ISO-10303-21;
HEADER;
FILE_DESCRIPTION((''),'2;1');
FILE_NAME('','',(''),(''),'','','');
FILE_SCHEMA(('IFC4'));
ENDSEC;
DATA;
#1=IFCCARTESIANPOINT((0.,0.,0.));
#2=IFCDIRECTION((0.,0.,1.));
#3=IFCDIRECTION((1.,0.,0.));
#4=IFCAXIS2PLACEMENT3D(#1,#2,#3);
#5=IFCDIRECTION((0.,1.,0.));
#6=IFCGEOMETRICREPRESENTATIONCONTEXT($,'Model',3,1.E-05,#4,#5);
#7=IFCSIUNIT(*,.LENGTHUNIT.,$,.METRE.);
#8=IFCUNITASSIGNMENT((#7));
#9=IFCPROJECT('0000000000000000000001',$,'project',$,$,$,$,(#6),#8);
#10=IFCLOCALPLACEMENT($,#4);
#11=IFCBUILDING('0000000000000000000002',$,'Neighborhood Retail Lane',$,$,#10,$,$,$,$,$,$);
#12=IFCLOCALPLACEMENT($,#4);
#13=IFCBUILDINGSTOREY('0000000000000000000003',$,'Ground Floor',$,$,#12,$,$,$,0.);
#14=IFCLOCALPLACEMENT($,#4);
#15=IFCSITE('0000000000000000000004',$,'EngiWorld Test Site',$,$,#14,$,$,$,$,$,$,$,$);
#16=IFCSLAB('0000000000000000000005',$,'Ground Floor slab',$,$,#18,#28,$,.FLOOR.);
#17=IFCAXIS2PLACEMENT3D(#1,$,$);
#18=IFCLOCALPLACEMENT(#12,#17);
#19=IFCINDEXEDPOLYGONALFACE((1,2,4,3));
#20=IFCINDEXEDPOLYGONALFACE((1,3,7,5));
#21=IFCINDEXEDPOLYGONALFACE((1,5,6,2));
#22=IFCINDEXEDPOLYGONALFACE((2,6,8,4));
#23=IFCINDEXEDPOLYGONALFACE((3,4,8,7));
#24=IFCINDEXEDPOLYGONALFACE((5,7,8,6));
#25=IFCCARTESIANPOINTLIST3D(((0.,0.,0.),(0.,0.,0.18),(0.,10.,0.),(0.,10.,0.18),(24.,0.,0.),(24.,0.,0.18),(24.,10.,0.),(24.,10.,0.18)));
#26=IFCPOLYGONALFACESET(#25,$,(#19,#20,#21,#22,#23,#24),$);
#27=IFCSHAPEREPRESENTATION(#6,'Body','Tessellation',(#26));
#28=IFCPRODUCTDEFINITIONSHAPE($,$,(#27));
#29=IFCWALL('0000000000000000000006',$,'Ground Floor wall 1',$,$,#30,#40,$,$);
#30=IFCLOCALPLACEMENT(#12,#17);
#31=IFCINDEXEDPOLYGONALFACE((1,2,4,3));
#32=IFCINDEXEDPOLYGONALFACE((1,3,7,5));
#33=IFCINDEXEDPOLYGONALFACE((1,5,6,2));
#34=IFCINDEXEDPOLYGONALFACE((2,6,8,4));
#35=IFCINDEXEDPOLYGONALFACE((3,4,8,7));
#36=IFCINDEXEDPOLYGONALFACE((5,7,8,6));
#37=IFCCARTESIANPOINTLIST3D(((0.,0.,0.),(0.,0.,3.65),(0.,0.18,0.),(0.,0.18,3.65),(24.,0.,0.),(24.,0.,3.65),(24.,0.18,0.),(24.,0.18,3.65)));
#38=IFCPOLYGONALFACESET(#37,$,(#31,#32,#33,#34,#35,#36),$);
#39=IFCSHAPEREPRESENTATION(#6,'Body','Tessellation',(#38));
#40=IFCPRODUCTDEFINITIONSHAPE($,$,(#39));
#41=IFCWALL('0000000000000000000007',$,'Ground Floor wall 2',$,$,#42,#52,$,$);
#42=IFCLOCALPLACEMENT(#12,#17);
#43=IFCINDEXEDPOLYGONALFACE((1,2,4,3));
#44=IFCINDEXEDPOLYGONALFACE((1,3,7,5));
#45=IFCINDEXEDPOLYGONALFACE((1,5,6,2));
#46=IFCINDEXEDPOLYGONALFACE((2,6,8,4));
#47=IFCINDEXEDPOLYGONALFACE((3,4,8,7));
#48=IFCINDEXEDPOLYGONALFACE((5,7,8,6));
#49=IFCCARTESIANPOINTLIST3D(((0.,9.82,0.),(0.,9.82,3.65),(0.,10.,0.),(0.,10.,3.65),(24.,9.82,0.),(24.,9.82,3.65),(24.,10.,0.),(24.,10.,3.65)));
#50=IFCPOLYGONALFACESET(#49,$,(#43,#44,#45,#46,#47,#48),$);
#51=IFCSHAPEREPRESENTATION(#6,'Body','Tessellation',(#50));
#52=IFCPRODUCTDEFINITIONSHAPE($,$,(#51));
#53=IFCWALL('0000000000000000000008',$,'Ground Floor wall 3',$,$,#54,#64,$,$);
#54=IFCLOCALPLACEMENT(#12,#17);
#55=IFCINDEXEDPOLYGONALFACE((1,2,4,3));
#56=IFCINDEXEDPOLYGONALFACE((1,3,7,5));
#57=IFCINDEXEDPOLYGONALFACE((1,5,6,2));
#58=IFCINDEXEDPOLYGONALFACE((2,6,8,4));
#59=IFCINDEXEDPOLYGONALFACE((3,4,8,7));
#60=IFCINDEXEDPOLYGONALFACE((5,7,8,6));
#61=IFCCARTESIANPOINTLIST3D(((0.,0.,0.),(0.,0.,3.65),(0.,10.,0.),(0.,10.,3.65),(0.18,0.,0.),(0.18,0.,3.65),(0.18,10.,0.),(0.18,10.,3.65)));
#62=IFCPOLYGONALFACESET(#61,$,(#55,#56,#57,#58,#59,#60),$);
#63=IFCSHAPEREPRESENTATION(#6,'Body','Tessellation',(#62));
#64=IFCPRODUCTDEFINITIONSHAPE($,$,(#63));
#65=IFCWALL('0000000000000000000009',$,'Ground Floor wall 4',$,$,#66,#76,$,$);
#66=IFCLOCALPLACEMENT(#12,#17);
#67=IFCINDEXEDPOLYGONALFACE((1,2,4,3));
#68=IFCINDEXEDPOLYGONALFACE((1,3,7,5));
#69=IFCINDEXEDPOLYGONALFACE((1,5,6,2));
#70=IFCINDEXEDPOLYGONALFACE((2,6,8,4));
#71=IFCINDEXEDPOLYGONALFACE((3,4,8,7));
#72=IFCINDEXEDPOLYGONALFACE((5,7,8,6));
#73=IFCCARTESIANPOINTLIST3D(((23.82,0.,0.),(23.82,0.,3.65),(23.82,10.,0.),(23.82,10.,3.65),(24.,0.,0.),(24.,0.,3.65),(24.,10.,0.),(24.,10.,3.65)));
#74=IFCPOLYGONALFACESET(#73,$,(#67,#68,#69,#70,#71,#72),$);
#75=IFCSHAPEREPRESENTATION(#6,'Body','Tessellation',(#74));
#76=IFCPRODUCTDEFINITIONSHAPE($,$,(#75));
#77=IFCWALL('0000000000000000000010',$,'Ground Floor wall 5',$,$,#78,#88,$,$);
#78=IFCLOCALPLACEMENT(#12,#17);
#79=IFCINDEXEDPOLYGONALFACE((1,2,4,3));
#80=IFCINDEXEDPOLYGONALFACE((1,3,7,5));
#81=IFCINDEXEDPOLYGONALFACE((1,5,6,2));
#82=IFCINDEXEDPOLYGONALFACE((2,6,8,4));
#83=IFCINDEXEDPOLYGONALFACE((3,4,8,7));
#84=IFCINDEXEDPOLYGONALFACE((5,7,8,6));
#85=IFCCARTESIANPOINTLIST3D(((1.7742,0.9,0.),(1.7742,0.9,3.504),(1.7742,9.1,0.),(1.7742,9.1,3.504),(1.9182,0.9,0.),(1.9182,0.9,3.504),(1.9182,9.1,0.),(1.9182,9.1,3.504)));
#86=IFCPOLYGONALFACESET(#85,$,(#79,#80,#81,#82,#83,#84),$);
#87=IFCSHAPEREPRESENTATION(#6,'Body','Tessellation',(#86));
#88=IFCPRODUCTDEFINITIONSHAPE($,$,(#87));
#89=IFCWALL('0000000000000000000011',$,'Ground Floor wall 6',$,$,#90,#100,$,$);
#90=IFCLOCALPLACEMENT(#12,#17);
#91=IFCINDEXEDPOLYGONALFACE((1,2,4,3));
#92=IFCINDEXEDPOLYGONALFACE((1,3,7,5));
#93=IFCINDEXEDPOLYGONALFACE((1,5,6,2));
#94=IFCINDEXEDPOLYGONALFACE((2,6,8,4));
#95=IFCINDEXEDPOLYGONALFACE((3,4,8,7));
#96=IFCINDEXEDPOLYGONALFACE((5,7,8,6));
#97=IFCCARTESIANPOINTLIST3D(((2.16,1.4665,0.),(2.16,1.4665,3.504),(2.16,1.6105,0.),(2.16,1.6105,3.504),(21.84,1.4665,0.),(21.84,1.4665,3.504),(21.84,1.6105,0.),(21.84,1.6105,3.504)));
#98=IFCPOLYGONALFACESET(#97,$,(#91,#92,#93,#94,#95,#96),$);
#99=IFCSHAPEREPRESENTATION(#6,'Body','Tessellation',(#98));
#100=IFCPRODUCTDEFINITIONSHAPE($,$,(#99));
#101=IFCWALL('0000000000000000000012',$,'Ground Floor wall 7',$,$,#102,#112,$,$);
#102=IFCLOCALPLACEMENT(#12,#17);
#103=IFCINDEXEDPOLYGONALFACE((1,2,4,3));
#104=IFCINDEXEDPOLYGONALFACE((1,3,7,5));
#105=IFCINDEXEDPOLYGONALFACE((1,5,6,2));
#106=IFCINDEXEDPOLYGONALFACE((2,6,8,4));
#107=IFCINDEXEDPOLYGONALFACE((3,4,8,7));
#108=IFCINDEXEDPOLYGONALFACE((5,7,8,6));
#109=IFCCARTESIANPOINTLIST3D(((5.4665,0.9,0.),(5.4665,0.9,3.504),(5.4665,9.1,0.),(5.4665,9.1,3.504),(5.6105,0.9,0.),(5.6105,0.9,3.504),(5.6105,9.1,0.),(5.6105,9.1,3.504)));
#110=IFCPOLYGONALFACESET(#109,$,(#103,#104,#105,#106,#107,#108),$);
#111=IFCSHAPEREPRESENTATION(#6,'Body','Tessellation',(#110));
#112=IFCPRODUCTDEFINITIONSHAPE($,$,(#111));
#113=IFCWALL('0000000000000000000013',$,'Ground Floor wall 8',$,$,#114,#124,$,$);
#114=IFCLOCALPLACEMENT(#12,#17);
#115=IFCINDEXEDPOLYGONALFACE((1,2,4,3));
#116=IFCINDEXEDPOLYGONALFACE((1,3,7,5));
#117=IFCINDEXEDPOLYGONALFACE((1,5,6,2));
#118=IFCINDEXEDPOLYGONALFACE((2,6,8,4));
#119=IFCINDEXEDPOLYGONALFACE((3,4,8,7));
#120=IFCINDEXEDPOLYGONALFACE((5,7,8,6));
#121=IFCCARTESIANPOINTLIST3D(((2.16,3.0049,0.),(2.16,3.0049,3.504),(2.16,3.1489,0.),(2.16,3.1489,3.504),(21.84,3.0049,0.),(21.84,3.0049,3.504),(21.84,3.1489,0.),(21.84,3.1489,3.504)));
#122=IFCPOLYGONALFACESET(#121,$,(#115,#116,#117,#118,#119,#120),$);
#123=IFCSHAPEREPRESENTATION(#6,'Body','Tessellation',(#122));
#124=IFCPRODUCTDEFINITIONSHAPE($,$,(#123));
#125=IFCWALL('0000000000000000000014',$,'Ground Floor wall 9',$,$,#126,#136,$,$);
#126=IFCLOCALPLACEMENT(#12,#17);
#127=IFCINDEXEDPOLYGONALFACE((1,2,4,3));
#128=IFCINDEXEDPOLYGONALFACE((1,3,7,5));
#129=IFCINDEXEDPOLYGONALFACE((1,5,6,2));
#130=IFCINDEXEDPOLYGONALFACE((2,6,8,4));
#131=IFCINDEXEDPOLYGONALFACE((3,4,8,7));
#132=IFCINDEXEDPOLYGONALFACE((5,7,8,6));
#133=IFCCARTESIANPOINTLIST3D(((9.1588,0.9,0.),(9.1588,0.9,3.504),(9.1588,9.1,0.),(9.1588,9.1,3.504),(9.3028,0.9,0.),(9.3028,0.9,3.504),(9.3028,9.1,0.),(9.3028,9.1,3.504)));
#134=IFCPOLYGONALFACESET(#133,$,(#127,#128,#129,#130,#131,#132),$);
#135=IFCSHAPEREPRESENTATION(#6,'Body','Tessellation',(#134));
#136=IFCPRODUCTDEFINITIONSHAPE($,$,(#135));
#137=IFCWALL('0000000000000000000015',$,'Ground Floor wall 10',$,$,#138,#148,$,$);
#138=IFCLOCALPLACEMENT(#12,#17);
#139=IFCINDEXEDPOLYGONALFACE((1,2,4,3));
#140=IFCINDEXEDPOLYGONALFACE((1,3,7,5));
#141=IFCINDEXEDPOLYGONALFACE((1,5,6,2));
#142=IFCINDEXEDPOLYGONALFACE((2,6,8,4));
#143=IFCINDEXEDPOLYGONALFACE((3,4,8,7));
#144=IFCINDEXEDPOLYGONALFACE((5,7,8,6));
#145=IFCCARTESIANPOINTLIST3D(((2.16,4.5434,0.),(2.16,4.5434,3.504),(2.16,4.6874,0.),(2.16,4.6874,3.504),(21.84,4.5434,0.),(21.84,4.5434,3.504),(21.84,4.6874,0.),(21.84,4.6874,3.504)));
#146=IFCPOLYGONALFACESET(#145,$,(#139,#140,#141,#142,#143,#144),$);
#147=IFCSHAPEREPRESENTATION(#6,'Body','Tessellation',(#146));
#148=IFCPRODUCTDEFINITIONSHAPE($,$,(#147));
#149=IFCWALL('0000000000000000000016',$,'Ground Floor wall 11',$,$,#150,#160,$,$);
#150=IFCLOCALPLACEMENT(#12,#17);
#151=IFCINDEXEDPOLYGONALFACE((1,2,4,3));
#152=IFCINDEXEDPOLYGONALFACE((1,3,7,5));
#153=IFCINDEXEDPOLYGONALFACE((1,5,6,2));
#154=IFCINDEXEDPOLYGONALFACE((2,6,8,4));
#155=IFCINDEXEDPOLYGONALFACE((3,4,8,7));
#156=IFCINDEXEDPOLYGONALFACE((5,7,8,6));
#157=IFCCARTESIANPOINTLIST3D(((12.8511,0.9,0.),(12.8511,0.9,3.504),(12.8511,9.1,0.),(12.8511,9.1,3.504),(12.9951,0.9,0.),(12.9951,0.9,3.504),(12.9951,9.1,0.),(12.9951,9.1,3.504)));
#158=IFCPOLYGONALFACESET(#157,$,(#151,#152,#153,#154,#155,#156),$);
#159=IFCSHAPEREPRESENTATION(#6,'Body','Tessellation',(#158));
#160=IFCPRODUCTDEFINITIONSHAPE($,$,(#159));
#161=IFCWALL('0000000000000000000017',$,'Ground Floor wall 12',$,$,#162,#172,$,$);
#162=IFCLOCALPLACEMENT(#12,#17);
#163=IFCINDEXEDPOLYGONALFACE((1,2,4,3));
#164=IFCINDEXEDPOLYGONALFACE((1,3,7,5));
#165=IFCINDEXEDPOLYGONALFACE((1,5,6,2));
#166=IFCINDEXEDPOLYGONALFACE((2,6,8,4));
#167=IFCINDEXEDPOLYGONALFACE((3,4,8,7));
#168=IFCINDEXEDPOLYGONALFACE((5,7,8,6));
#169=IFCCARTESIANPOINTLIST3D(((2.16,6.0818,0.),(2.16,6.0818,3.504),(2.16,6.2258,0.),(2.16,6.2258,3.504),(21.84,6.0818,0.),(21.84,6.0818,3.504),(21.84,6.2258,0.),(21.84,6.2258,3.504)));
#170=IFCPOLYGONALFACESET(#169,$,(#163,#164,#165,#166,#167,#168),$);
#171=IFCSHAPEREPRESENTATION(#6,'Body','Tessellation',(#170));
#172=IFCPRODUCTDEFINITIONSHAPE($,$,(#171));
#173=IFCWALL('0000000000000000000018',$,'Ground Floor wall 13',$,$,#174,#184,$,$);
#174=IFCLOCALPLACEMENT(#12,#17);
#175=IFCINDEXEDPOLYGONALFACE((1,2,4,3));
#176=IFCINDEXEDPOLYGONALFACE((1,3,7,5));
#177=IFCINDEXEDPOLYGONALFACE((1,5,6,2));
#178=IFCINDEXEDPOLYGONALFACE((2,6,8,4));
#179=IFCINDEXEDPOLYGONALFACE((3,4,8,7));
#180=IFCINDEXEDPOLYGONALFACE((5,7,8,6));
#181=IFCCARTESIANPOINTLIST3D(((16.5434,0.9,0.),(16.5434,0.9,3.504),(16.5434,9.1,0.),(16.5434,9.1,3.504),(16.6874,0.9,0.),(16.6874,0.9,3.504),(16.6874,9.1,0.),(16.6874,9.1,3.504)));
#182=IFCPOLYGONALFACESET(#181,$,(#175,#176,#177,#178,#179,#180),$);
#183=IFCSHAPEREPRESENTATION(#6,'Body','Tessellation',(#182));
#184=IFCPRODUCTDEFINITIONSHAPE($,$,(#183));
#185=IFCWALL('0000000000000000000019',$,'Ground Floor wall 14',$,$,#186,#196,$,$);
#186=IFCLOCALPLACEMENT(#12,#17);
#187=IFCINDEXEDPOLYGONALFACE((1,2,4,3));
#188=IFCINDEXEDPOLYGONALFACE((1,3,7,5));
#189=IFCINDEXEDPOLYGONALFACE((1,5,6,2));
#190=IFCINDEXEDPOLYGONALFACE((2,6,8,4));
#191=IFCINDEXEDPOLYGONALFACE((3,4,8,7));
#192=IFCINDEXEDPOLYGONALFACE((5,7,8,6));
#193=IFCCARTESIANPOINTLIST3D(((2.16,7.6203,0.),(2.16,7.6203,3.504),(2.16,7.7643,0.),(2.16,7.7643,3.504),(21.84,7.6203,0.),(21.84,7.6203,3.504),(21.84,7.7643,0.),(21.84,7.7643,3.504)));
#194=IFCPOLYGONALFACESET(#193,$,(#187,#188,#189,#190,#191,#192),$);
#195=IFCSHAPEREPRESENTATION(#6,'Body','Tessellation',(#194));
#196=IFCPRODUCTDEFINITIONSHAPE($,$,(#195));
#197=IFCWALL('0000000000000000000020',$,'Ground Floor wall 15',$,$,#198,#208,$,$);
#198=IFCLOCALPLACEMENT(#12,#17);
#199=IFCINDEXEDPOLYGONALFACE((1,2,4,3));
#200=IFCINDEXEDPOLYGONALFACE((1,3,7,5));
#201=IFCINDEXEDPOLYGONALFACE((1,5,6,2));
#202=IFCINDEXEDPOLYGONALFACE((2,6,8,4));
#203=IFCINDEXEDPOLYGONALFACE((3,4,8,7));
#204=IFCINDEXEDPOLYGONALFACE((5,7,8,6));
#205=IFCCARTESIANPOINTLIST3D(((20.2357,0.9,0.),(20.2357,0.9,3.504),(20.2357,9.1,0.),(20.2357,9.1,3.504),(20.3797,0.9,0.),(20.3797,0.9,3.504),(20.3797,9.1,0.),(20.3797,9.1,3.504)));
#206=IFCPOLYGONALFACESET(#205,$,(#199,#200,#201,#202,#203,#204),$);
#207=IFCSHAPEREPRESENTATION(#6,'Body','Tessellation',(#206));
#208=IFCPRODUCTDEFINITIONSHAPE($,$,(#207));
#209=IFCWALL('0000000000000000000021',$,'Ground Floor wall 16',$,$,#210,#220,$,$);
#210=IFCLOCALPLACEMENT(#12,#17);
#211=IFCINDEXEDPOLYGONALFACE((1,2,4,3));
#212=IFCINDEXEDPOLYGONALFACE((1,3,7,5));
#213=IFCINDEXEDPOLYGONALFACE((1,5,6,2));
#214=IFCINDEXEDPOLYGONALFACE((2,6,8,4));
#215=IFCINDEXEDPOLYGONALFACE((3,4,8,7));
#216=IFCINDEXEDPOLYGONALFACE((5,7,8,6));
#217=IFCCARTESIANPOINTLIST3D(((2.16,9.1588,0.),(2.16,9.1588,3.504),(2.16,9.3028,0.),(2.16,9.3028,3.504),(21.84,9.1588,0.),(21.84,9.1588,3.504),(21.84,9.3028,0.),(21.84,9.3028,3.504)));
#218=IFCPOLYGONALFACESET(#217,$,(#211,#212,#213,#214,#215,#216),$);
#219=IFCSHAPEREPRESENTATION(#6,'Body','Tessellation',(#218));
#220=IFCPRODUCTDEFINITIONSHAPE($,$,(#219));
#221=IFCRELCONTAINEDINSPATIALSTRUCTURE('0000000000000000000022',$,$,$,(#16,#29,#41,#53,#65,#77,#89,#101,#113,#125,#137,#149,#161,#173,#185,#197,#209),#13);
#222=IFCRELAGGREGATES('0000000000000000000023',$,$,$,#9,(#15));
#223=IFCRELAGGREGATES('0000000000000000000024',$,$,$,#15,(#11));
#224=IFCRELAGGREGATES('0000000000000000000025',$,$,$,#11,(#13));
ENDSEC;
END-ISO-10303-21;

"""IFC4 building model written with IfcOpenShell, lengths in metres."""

from ifc_helpers import new_model, si_unit, direction, frame, origin_with_axes, origin_2d_with_axis, place, context, project, spatial, rectangle, extrude, element, save


model = new_model("IFC4")

# Units and contexts
model_context = context("Model", 3, precision=1e-05, world=origin_with_axes(), true_north=direction((0.0, 1.0, 0.0)))
ifc_project = project(units=[si_unit("LENGTHUNIT", "METRE")], contexts=[model_context])

# Site, building, storey
site_placement = place(None, origin_with_axes())
site = spatial("IfcSite", under=ifc_project, at=site_placement, Name="EngiWorld Test Site")
building_placement = place(None, origin_with_axes())
building = spatial("IfcBuilding", under=site, at=building_placement, Name="Neighborhood Retail Lane")
storey_placement = place(None, origin_with_axes())
storey = spatial("IfcBuildingStorey", under=building, at=storey_placement, Name="Ground Floor", Elevation=0.0)

# Slab
slab_placement = place(None, frame((12.0, 5.0, 0.0), z_axis=(0.0, 0.0, 1.0), x_axis=(1.0, 0.0, 0.0)))
element("IfcSlab", 1, at=slab_placement, inside=storey, Name="Ground Floor slab", PredefinedType="FLOOR", context=model_context, shape_type="SweptSolid", body=[
    extrude(rectangle(XDim=24.0, YDim=10.0, at=origin_2d_with_axis()), origin_with_axes(), (0.0, 0.0, 1.0), 0.18),
])

# Walls
for number, where, z_axis, x_axis, name in (
    (2, (12.0, 0.09, 0.0), (0.0, 0.0, 1.0), (1.0, 0.0, 0.0), "Ground Floor wall 1"),
    (3, (12.0, 9.91, 0.0), (0.0, 0.0, 1.0), (1.0, 0.0, 0.0), "Ground Floor wall 2"),
):
    element("IfcWall", number, at=place(None, frame(where, z_axis=z_axis, x_axis=x_axis)), inside=storey, Name=name, context=model_context, shape_type="SweptSolid", body=[
        extrude(rectangle(XDim=24.0, YDim=0.18, at=origin_2d_with_axis()), origin_with_axes(), (0.0, 0.0, 1.0), 3.65),
    ])
for number, where, z_axis, x_axis, name in (
    (4, (0.09, 5.0, 0.0), (0.0, 0.0, 1.0), (1.0, 0.0, 0.0), "Ground Floor wall 3"),
    (5, (23.91, 5.0, 0.0), (0.0, 0.0, 1.0), (1.0, 0.0, 0.0), "Ground Floor wall 4"),
):
    element("IfcWall", number, at=place(None, frame(where, z_axis=z_axis, x_axis=x_axis)), inside=storey, Name=name, context=model_context, shape_type="SweptSolid", body=[
        extrude(rectangle(XDim=0.18, YDim=10.0, at=origin_2d_with_axis()), origin_with_axes(), (0.0, 0.0, 1.0), 3.65),
    ])
wall_1_placement = place(None, frame((1.8462, 5.0, 0.0), z_axis=(0.0, 0.0, 1.0), x_axis=(1.0, 0.0, 0.0)))
element("IfcWall", 6, at=wall_1_placement, inside=storey, Name="Ground Floor wall 5", context=model_context, shape_type="SweptSolid", body=[
    extrude(rectangle(XDim=0.144, YDim=8.2, at=origin_2d_with_axis()), origin_with_axes(), (0.0, 0.0, 1.0), 3.504),
])
wall_2_placement = place(None, frame((12.0, 1.5385, 0.0), z_axis=(0.0, 0.0, 1.0), x_axis=(1.0, 0.0, 0.0)))
element("IfcWall", 7, at=wall_2_placement, inside=storey, Name="Ground Floor wall 6", context=model_context, shape_type="SweptSolid", body=[
    extrude(rectangle(XDim=19.68, YDim=0.144, at=origin_2d_with_axis()), origin_with_axes(), (0.0, 0.0, 1.0), 3.504),
])
wall_3_placement = place(None, frame((5.5385, 5.0, 0.0), z_axis=(0.0, 0.0, 1.0), x_axis=(1.0, 0.0, 0.0)))
element("IfcWall", 8, at=wall_3_placement, inside=storey, Name="Ground Floor wall 7", context=model_context, shape_type="SweptSolid", body=[
    extrude(rectangle(XDim=0.144, YDim=8.2, at=origin_2d_with_axis()), origin_with_axes(), (0.0, 0.0, 1.0), 3.504),
])
wall_4_placement = place(None, frame((12.0, 3.0769, 0.0), z_axis=(0.0, 0.0, 1.0), x_axis=(1.0, 0.0, 0.0)))
element("IfcWall", 9, at=wall_4_placement, inside=storey, Name="Ground Floor wall 8", context=model_context, shape_type="SweptSolid", body=[
    extrude(rectangle(XDim=19.68, YDim=0.144, at=origin_2d_with_axis()), origin_with_axes(), (0.0, 0.0, 1.0), 3.504),
])
wall_5_placement = place(None, frame((9.2308, 5.0, 0.0), z_axis=(0.0, 0.0, 1.0), x_axis=(1.0, 0.0, 0.0)))
element("IfcWall", 10, at=wall_5_placement, inside=storey, Name="Ground Floor wall 9", context=model_context, shape_type="SweptSolid", body=[
    extrude(rectangle(XDim=0.144, YDim=8.2, at=origin_2d_with_axis()), origin_with_axes(), (0.0, 0.0, 1.0), 3.504),
])
wall_6_placement = place(None, frame((12.0, 4.6154, 0.0), z_axis=(0.0, 0.0, 1.0), x_axis=(1.0, 0.0, 0.0)))
element("IfcWall", 11, at=wall_6_placement, inside=storey, Name="Ground Floor wall 10", context=model_context, shape_type="SweptSolid", body=[
    extrude(rectangle(XDim=19.68, YDim=0.144, at=origin_2d_with_axis()), origin_with_axes(), (0.0, 0.0, 1.0), 3.504),
])
wall_7_placement = place(None, frame((12.9231, 5.0, 0.0), z_axis=(0.0, 0.0, 1.0), x_axis=(1.0, 0.0, 0.0)))
element("IfcWall", 12, at=wall_7_placement, inside=storey, Name="Ground Floor wall 11", context=model_context, shape_type="SweptSolid", body=[
    extrude(rectangle(XDim=0.144, YDim=8.2, at=origin_2d_with_axis()), origin_with_axes(), (0.0, 0.0, 1.0), 3.504),
])
wall_8_placement = place(None, frame((12.0, 6.1538, 0.0), z_axis=(0.0, 0.0, 1.0), x_axis=(1.0, 0.0, 0.0)))
element("IfcWall", 13, at=wall_8_placement, inside=storey, Name="Ground Floor wall 12", context=model_context, shape_type="SweptSolid", body=[
    extrude(rectangle(XDim=19.68, YDim=0.144, at=origin_2d_with_axis()), origin_with_axes(), (0.0, 0.0, 1.0), 3.504),
])
wall_9_placement = place(None, frame((16.6154, 5.0, 0.0), z_axis=(0.0, 0.0, 1.0), x_axis=(1.0, 0.0, 0.0)))
element("IfcWall", 14, at=wall_9_placement, inside=storey, Name="Ground Floor wall 13", context=model_context, shape_type="SweptSolid", body=[
    extrude(rectangle(XDim=0.144, YDim=8.2, at=origin_2d_with_axis()), origin_with_axes(), (0.0, 0.0, 1.0), 3.504),
])
wall_10_placement = place(None, frame((12.0, 7.6923, 0.0), z_axis=(0.0, 0.0, 1.0), x_axis=(1.0, 0.0, 0.0)))
element("IfcWall", 15, at=wall_10_placement, inside=storey, Name="Ground Floor wall 14", context=model_context, shape_type="SweptSolid", body=[
    extrude(rectangle(XDim=19.68, YDim=0.144, at=origin_2d_with_axis()), origin_with_axes(), (0.0, 0.0, 1.0), 3.504),
])
wall_11_placement = place(None, frame((20.3077, 5.0, 0.0), z_axis=(0.0, 0.0, 1.0), x_axis=(1.0, 0.0, 0.0)))
element("IfcWall", 16, at=wall_11_placement, inside=storey, Name="Ground Floor wall 15", context=model_context, shape_type="SweptSolid", body=[
    extrude(rectangle(XDim=0.144, YDim=8.2, at=origin_2d_with_axis()), origin_with_axes(), (0.0, 0.0, 1.0), 3.504),
])
wall_12_placement = place(None, frame((12.0, 9.2308, 0.0), z_axis=(0.0, 0.0, 1.0), x_axis=(1.0, 0.0, 0.0)))
element("IfcWall", 17, at=wall_12_placement, inside=storey, Name="Ground Floor wall 16", context=model_context, shape_type="SweptSolid", body=[
    extrude(rectangle(XDim=19.68, YDim=0.144, at=origin_2d_with_axis()), origin_with_axes(), (0.0, 0.0, 1.0), 3.504),
])

save(model, "model.ifc")
